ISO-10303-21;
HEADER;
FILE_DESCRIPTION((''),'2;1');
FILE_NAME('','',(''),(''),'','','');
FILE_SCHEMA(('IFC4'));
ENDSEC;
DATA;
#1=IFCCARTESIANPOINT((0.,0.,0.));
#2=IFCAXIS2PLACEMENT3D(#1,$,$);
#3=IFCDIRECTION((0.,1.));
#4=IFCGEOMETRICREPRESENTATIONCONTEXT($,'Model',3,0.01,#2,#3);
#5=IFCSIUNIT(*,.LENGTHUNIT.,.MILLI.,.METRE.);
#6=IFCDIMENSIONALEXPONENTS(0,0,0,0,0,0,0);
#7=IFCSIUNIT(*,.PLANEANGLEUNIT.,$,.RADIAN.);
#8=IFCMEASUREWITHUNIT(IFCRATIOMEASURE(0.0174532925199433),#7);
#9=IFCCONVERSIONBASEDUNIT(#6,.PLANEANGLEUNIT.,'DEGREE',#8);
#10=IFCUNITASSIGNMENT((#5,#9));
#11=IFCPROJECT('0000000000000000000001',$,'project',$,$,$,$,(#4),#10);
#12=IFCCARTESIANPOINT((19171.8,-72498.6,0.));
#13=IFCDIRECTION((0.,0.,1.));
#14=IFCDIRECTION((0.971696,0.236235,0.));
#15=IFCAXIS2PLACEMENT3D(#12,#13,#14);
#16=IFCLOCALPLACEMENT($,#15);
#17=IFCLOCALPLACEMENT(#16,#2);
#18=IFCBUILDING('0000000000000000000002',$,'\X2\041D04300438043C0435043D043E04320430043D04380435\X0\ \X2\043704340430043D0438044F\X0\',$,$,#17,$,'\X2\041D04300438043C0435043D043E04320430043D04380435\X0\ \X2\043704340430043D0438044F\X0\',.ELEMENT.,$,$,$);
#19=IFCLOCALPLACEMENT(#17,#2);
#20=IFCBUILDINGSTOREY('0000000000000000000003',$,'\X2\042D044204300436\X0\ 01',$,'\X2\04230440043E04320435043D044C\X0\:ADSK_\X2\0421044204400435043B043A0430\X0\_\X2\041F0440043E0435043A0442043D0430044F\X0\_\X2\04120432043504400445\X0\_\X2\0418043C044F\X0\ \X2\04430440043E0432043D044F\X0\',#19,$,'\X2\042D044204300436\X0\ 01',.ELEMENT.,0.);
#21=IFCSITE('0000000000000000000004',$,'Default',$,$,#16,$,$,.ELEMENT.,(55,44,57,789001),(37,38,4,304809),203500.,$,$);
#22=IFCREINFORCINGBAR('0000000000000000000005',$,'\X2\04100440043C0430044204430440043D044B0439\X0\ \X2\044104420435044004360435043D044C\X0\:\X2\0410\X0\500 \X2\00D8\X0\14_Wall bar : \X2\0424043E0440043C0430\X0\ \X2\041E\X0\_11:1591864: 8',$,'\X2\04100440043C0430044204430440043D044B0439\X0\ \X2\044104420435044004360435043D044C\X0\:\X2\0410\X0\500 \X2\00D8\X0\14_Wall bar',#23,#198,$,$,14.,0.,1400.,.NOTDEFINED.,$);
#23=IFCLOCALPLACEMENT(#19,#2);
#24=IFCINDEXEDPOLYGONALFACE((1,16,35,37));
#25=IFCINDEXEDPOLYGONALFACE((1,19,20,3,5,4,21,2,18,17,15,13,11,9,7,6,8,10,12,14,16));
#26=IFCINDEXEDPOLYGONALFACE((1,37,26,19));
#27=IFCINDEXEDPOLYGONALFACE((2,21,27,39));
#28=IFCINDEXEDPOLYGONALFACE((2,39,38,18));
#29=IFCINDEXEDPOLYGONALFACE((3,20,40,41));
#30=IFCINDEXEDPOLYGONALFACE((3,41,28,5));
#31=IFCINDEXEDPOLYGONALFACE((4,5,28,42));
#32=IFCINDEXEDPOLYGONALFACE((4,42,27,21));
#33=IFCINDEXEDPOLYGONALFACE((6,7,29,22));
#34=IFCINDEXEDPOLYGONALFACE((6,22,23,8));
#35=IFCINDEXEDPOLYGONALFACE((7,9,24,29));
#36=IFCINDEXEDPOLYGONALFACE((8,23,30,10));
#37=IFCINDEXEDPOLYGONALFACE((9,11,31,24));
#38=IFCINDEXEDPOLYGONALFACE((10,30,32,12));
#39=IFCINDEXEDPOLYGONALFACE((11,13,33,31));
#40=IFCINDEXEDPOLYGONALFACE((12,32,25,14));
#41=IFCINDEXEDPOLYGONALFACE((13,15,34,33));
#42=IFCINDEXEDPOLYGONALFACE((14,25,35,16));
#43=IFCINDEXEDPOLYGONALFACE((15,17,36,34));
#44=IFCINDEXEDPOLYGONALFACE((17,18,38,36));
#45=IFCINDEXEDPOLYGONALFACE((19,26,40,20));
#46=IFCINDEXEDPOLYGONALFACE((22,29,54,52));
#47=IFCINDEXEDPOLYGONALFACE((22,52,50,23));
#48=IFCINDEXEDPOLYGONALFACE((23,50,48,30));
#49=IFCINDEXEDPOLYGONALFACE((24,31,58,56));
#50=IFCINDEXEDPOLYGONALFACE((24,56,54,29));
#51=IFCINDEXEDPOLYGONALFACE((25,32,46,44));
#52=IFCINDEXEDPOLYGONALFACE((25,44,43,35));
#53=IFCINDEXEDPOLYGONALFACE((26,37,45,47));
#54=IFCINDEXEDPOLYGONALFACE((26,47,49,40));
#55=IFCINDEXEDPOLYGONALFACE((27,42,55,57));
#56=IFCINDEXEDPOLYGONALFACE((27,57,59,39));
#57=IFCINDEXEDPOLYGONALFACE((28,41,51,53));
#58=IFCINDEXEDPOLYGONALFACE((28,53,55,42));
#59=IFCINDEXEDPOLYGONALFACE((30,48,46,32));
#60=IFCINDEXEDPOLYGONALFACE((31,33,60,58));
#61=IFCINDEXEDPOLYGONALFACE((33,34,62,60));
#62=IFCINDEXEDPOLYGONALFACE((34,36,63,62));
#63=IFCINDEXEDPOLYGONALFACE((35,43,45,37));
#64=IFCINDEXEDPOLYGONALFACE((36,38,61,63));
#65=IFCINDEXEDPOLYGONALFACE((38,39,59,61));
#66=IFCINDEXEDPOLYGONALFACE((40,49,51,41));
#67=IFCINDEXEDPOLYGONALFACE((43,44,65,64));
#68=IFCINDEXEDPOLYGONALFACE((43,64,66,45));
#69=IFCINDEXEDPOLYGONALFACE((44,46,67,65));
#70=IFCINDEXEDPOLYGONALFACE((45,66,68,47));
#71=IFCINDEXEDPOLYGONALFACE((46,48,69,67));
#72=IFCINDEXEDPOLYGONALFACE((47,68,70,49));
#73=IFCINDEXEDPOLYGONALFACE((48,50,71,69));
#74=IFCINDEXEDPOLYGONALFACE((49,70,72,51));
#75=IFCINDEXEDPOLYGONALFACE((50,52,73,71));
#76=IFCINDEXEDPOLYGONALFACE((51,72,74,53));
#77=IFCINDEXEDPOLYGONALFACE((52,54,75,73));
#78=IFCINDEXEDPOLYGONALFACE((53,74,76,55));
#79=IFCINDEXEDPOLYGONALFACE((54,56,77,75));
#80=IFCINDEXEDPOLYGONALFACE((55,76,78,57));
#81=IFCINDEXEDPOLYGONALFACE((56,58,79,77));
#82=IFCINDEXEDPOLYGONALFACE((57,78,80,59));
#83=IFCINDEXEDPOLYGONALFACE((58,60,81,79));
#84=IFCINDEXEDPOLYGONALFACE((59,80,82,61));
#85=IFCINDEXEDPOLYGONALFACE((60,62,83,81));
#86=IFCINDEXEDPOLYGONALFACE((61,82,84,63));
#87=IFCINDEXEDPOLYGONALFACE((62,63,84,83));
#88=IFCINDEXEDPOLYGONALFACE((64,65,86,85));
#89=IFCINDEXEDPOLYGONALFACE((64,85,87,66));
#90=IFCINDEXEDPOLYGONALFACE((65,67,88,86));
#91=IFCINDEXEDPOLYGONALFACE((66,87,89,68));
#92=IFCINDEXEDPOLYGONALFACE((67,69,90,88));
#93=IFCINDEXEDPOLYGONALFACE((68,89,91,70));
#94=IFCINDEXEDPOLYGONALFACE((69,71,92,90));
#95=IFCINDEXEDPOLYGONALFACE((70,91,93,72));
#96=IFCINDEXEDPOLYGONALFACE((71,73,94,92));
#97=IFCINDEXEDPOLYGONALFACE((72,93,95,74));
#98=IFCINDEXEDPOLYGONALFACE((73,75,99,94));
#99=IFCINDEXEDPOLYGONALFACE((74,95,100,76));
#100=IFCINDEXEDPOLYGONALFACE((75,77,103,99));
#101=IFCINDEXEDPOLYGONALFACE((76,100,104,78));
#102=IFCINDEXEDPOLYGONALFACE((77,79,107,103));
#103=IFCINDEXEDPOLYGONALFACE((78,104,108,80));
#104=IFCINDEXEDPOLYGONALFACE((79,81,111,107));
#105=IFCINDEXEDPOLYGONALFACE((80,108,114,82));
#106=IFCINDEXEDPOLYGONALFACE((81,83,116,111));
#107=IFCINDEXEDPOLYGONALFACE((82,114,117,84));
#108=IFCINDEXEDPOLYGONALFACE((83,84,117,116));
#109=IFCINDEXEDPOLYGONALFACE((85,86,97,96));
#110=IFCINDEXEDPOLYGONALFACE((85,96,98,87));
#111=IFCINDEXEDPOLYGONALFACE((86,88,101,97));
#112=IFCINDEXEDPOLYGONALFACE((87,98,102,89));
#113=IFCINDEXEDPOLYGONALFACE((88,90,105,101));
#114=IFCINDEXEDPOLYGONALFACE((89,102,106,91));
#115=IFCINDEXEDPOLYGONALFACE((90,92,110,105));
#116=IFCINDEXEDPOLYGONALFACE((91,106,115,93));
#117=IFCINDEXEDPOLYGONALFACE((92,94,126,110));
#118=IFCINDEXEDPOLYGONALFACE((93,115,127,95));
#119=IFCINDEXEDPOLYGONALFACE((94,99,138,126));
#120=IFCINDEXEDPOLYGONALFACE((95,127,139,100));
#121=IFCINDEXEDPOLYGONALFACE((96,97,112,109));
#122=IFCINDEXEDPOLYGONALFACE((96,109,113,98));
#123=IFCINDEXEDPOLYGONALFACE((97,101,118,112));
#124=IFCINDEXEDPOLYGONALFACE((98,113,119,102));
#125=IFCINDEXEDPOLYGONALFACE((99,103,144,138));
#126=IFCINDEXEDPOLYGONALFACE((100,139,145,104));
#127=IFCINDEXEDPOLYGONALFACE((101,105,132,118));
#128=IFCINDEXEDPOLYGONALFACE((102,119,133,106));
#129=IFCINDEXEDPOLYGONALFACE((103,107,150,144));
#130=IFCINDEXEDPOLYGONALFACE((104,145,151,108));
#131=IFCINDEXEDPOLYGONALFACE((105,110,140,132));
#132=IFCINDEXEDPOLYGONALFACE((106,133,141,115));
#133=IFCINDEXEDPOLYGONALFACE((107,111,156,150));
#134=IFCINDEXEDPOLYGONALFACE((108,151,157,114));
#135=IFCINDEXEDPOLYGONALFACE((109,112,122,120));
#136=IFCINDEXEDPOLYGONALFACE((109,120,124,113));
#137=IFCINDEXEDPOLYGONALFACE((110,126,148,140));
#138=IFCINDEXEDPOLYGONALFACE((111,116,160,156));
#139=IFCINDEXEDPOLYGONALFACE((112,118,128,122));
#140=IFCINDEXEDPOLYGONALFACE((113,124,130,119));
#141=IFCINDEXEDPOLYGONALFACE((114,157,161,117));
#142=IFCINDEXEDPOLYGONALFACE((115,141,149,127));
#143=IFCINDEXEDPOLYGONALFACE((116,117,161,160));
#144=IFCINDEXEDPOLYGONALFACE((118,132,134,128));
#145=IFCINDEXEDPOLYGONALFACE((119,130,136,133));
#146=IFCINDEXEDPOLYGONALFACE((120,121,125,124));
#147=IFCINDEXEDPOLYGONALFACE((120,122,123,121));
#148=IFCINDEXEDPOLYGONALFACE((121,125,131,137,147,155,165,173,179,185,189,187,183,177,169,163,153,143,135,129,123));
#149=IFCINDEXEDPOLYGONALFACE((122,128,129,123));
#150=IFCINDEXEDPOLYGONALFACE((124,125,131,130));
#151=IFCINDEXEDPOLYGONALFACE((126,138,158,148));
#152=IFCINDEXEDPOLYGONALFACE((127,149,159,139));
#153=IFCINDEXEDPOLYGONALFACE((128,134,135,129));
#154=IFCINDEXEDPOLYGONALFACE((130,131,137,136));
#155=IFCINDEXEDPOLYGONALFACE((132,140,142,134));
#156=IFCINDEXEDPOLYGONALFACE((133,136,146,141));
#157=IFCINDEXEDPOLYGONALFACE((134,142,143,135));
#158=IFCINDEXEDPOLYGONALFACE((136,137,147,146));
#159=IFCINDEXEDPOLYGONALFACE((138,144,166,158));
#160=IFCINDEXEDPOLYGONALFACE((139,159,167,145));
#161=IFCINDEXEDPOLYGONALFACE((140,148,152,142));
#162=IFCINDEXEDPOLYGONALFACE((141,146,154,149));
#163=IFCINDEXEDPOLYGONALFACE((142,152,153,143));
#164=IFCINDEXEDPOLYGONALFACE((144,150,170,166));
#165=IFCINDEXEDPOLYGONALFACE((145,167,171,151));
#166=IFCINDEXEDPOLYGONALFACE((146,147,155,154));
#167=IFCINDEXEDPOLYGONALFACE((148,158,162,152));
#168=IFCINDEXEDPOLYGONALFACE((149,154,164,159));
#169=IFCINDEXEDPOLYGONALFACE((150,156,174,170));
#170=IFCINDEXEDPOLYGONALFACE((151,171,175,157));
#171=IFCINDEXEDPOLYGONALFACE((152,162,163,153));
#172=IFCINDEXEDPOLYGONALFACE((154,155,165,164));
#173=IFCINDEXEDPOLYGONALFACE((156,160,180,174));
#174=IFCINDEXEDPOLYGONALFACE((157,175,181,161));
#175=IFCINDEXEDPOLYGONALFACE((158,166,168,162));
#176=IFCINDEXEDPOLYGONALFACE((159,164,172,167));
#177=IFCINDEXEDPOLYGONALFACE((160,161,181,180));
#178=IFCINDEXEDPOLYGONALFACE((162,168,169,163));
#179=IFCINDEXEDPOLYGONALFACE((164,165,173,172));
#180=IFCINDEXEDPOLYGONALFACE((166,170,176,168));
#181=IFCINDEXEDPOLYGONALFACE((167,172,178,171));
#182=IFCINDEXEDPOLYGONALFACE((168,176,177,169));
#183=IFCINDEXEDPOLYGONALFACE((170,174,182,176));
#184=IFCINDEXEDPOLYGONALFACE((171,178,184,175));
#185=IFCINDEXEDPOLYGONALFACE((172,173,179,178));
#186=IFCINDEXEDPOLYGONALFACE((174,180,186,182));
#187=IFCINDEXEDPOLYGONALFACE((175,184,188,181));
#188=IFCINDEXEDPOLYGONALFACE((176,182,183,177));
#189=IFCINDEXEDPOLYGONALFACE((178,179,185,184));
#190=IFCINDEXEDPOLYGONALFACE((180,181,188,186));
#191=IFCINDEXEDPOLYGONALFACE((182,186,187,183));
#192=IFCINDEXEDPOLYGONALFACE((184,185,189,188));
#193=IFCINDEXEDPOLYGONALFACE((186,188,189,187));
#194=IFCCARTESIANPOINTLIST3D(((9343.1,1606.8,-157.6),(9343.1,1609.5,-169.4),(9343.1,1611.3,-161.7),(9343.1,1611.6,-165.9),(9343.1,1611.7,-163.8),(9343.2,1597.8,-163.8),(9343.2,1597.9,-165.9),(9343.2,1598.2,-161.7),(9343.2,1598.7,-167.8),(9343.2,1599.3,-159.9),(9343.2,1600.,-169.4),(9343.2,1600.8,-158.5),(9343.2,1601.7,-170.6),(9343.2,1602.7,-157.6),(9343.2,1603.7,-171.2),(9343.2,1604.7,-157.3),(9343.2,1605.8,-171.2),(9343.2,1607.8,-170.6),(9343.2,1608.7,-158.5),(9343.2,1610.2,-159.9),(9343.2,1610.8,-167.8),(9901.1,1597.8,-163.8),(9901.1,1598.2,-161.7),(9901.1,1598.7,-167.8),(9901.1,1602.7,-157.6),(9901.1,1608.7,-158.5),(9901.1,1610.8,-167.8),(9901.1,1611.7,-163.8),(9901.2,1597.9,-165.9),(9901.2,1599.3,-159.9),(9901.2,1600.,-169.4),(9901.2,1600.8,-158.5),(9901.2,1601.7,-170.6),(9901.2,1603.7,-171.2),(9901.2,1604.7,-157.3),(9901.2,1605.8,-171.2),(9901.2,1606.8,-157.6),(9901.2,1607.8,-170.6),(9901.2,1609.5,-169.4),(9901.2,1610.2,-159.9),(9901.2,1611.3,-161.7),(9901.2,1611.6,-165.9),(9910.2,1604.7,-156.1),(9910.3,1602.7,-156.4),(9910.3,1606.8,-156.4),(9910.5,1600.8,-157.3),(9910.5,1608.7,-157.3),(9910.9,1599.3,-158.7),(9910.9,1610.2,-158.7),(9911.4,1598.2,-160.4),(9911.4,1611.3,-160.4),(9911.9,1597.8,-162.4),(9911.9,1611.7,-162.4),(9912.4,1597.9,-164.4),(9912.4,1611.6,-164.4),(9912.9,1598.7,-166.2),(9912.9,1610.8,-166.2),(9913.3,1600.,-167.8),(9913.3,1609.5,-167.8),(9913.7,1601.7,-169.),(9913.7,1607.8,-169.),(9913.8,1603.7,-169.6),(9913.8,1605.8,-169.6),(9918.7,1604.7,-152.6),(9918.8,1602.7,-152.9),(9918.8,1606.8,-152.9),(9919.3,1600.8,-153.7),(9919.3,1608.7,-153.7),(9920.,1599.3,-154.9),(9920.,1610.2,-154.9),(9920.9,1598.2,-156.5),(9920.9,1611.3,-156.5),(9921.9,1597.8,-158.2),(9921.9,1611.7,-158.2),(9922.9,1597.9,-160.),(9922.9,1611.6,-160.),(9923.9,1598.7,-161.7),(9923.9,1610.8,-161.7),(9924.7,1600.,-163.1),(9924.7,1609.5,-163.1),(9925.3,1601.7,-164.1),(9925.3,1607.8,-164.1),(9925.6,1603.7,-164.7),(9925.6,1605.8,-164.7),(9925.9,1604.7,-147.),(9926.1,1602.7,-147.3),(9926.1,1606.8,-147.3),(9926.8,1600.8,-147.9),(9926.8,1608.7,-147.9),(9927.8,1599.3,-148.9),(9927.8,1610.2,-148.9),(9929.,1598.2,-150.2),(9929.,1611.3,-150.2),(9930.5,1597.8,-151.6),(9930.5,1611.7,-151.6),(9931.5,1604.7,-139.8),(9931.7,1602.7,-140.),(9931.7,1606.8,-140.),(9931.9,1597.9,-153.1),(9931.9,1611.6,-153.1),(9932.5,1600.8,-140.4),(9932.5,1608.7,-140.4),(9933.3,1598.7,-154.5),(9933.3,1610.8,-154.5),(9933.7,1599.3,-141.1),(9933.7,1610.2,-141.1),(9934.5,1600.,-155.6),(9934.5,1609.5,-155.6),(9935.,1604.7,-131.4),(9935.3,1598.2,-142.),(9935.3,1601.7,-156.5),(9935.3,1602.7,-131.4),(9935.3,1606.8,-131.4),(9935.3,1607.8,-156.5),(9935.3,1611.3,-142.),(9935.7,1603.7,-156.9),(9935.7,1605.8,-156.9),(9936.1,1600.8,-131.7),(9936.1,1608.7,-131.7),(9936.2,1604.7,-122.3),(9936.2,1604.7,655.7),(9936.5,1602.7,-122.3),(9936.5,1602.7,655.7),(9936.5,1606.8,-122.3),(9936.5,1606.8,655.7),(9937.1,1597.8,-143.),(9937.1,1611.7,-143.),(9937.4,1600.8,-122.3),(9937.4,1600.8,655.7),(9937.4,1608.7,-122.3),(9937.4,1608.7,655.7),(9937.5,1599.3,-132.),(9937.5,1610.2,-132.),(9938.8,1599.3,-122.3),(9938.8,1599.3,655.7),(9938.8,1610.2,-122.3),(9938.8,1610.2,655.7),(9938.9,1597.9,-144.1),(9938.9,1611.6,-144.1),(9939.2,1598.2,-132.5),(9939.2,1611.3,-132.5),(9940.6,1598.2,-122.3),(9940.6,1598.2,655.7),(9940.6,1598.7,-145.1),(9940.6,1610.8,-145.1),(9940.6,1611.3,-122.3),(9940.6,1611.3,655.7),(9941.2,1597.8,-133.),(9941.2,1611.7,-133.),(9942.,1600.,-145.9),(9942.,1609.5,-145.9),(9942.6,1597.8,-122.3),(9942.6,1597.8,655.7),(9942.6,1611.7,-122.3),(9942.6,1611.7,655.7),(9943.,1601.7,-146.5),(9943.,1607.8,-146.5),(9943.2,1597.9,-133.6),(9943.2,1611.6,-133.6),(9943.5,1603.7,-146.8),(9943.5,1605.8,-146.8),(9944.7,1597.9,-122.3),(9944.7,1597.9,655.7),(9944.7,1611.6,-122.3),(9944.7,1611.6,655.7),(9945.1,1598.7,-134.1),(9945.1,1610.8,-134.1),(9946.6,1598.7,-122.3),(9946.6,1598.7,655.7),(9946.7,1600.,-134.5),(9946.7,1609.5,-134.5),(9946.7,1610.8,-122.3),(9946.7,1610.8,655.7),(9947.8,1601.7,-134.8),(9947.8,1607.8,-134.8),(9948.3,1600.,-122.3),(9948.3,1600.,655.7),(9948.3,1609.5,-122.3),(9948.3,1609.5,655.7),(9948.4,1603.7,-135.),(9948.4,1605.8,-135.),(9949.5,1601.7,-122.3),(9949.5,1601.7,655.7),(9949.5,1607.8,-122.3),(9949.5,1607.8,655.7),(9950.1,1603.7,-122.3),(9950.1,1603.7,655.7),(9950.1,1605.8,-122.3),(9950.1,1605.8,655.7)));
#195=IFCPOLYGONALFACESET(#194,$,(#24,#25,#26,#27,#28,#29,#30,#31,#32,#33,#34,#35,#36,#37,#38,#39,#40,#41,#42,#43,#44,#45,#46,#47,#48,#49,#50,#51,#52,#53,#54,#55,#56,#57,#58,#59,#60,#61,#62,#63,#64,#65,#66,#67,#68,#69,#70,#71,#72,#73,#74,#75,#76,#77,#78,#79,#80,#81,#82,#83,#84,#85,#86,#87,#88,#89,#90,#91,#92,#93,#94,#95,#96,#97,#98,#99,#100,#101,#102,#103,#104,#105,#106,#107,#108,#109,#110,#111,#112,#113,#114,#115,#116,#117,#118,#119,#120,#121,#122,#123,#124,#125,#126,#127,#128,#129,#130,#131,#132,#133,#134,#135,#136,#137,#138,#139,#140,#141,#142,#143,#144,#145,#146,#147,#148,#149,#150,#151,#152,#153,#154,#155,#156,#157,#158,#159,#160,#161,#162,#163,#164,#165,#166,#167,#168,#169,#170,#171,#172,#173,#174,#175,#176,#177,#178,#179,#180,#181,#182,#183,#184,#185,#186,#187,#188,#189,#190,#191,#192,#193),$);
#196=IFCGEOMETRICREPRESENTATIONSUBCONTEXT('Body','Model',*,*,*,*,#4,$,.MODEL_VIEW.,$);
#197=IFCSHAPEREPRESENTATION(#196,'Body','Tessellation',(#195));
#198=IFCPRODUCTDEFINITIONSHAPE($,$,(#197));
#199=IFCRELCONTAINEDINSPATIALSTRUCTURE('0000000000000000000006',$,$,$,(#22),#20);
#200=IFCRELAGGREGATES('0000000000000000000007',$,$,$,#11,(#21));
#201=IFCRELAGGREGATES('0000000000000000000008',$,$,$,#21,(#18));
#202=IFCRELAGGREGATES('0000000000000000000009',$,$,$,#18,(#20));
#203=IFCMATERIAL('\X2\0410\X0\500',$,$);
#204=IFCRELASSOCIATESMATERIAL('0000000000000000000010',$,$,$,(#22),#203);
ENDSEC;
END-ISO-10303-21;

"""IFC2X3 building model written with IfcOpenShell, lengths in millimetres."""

from ifc_helpers import new_model, entity, si_unit, converted_unit, direction, frame, origin, place, context, subcontext, project, spatial, material, element, save


model = new_model("IFC2X3")

# Units and contexts
model_context = context("Model", 3, precision=0.01, world=origin(), true_north=direction((0.0, 1.0)))
body_context = subcontext(model_context, "Body", "Model", "MODEL_VIEW")
ifc_project = project(units=[si_unit("LENGTHUNIT", "METRE", prefix="MILLI"), converted_unit("PLANEANGLEUNIT", "DEGREE", entity("IfcRatioMeasure", 0.0174532925199433), si_unit("PLANEANGLEUNIT", "RADIAN"), dimensions=[0, 0, 0, 0, 0, 0, 0])], contexts=[model_context])

# Site, building, storey
site_placement = place(None, frame((19171.8, -72498.6, 0.0), z_axis=(0.0, 0.0, 1.0), x_axis=(0.971696, 0.236235, 0.0)))
site = spatial("IfcSite", under=ifc_project, at=site_placement, Name="Default", CompositionType="ELEMENT", RefLatitude=(55, 44, 57, 789001), RefLongitude=(37, 38, 4, 304809), RefElevation=203500.0)
building_placement = place(site_placement, origin())
building = spatial("IfcBuilding", under=site, at=building_placement, Name="Наименование здания", LongName="Наименование здания", CompositionType="ELEMENT")
storey_placement = place(building_placement, origin())
storey = spatial("IfcBuildingStorey", under=building, at=storey_placement, Name="Этаж 01", ObjectType="Уровень:ADSK_Стрелка_Проектная_Вверх_Имя уровня", LongName="Этаж 01", CompositionType="ELEMENT", Elevation=0.0)

# Reinforcing bar
ifc_material = material(Name="А500")
placement = place(storey_placement, origin())
element("IfcReinforcingBar", 1, at=placement, inside=storey, material=ifc_material, Name="Арматурный стержень:А500 Ø14_Wall bar : Форма О_11:1591864: 8", ObjectType="Арматурный стержень:А500 Ø14_Wall bar", BarLength=1400.0, BarRole="NOTDEFINED", CrossSectionArea=0.0, NominalDiameter=14.0, context=body_context, shape_type="AdvancedSweptSolid", body=[
    entity("IfcSweptDiskSolid", entity("IfcCompositeCurve", [entity("IfcCompositeCurveSegment", "CONTINUOUS", True, entity("IfcPolyline", [entity("IfcCartesianPoint", [9943.1, 1604.7, 655.7]), entity("IfcCartesianPoint", [9943.1, 1604.7, -122.3])])), entity("IfcCompositeCurveSegment", "CONTINUOUS", True, entity("IfcTrimmedCurve", entity("IfcCircle", entity("IfcAxis2Placement3D", entity("IfcCartesianPoint", [9901.1, 1604.7, -122.3]), entity("IfcDirection", [0.0, 1.0, 0.0]), entity("IfcDirection", [0.0, 0.0, -1.0])), 42.0), [entity("IfcParameterValue", 270.0)], [entity("IfcParameterValue", 360.0)], True, "PARAMETER")), entity("IfcCompositeCurveSegment", "CONTINUOUS", True, entity("IfcPolyline", [entity("IfcCartesianPoint", [9901.1, 1604.7, -164.3]), entity("IfcCartesianPoint", [9343.1, 1604.7, -164.3])]))], False), 7.0, None, 0.0, 92.0),
])

save(model, "model.ifc")
